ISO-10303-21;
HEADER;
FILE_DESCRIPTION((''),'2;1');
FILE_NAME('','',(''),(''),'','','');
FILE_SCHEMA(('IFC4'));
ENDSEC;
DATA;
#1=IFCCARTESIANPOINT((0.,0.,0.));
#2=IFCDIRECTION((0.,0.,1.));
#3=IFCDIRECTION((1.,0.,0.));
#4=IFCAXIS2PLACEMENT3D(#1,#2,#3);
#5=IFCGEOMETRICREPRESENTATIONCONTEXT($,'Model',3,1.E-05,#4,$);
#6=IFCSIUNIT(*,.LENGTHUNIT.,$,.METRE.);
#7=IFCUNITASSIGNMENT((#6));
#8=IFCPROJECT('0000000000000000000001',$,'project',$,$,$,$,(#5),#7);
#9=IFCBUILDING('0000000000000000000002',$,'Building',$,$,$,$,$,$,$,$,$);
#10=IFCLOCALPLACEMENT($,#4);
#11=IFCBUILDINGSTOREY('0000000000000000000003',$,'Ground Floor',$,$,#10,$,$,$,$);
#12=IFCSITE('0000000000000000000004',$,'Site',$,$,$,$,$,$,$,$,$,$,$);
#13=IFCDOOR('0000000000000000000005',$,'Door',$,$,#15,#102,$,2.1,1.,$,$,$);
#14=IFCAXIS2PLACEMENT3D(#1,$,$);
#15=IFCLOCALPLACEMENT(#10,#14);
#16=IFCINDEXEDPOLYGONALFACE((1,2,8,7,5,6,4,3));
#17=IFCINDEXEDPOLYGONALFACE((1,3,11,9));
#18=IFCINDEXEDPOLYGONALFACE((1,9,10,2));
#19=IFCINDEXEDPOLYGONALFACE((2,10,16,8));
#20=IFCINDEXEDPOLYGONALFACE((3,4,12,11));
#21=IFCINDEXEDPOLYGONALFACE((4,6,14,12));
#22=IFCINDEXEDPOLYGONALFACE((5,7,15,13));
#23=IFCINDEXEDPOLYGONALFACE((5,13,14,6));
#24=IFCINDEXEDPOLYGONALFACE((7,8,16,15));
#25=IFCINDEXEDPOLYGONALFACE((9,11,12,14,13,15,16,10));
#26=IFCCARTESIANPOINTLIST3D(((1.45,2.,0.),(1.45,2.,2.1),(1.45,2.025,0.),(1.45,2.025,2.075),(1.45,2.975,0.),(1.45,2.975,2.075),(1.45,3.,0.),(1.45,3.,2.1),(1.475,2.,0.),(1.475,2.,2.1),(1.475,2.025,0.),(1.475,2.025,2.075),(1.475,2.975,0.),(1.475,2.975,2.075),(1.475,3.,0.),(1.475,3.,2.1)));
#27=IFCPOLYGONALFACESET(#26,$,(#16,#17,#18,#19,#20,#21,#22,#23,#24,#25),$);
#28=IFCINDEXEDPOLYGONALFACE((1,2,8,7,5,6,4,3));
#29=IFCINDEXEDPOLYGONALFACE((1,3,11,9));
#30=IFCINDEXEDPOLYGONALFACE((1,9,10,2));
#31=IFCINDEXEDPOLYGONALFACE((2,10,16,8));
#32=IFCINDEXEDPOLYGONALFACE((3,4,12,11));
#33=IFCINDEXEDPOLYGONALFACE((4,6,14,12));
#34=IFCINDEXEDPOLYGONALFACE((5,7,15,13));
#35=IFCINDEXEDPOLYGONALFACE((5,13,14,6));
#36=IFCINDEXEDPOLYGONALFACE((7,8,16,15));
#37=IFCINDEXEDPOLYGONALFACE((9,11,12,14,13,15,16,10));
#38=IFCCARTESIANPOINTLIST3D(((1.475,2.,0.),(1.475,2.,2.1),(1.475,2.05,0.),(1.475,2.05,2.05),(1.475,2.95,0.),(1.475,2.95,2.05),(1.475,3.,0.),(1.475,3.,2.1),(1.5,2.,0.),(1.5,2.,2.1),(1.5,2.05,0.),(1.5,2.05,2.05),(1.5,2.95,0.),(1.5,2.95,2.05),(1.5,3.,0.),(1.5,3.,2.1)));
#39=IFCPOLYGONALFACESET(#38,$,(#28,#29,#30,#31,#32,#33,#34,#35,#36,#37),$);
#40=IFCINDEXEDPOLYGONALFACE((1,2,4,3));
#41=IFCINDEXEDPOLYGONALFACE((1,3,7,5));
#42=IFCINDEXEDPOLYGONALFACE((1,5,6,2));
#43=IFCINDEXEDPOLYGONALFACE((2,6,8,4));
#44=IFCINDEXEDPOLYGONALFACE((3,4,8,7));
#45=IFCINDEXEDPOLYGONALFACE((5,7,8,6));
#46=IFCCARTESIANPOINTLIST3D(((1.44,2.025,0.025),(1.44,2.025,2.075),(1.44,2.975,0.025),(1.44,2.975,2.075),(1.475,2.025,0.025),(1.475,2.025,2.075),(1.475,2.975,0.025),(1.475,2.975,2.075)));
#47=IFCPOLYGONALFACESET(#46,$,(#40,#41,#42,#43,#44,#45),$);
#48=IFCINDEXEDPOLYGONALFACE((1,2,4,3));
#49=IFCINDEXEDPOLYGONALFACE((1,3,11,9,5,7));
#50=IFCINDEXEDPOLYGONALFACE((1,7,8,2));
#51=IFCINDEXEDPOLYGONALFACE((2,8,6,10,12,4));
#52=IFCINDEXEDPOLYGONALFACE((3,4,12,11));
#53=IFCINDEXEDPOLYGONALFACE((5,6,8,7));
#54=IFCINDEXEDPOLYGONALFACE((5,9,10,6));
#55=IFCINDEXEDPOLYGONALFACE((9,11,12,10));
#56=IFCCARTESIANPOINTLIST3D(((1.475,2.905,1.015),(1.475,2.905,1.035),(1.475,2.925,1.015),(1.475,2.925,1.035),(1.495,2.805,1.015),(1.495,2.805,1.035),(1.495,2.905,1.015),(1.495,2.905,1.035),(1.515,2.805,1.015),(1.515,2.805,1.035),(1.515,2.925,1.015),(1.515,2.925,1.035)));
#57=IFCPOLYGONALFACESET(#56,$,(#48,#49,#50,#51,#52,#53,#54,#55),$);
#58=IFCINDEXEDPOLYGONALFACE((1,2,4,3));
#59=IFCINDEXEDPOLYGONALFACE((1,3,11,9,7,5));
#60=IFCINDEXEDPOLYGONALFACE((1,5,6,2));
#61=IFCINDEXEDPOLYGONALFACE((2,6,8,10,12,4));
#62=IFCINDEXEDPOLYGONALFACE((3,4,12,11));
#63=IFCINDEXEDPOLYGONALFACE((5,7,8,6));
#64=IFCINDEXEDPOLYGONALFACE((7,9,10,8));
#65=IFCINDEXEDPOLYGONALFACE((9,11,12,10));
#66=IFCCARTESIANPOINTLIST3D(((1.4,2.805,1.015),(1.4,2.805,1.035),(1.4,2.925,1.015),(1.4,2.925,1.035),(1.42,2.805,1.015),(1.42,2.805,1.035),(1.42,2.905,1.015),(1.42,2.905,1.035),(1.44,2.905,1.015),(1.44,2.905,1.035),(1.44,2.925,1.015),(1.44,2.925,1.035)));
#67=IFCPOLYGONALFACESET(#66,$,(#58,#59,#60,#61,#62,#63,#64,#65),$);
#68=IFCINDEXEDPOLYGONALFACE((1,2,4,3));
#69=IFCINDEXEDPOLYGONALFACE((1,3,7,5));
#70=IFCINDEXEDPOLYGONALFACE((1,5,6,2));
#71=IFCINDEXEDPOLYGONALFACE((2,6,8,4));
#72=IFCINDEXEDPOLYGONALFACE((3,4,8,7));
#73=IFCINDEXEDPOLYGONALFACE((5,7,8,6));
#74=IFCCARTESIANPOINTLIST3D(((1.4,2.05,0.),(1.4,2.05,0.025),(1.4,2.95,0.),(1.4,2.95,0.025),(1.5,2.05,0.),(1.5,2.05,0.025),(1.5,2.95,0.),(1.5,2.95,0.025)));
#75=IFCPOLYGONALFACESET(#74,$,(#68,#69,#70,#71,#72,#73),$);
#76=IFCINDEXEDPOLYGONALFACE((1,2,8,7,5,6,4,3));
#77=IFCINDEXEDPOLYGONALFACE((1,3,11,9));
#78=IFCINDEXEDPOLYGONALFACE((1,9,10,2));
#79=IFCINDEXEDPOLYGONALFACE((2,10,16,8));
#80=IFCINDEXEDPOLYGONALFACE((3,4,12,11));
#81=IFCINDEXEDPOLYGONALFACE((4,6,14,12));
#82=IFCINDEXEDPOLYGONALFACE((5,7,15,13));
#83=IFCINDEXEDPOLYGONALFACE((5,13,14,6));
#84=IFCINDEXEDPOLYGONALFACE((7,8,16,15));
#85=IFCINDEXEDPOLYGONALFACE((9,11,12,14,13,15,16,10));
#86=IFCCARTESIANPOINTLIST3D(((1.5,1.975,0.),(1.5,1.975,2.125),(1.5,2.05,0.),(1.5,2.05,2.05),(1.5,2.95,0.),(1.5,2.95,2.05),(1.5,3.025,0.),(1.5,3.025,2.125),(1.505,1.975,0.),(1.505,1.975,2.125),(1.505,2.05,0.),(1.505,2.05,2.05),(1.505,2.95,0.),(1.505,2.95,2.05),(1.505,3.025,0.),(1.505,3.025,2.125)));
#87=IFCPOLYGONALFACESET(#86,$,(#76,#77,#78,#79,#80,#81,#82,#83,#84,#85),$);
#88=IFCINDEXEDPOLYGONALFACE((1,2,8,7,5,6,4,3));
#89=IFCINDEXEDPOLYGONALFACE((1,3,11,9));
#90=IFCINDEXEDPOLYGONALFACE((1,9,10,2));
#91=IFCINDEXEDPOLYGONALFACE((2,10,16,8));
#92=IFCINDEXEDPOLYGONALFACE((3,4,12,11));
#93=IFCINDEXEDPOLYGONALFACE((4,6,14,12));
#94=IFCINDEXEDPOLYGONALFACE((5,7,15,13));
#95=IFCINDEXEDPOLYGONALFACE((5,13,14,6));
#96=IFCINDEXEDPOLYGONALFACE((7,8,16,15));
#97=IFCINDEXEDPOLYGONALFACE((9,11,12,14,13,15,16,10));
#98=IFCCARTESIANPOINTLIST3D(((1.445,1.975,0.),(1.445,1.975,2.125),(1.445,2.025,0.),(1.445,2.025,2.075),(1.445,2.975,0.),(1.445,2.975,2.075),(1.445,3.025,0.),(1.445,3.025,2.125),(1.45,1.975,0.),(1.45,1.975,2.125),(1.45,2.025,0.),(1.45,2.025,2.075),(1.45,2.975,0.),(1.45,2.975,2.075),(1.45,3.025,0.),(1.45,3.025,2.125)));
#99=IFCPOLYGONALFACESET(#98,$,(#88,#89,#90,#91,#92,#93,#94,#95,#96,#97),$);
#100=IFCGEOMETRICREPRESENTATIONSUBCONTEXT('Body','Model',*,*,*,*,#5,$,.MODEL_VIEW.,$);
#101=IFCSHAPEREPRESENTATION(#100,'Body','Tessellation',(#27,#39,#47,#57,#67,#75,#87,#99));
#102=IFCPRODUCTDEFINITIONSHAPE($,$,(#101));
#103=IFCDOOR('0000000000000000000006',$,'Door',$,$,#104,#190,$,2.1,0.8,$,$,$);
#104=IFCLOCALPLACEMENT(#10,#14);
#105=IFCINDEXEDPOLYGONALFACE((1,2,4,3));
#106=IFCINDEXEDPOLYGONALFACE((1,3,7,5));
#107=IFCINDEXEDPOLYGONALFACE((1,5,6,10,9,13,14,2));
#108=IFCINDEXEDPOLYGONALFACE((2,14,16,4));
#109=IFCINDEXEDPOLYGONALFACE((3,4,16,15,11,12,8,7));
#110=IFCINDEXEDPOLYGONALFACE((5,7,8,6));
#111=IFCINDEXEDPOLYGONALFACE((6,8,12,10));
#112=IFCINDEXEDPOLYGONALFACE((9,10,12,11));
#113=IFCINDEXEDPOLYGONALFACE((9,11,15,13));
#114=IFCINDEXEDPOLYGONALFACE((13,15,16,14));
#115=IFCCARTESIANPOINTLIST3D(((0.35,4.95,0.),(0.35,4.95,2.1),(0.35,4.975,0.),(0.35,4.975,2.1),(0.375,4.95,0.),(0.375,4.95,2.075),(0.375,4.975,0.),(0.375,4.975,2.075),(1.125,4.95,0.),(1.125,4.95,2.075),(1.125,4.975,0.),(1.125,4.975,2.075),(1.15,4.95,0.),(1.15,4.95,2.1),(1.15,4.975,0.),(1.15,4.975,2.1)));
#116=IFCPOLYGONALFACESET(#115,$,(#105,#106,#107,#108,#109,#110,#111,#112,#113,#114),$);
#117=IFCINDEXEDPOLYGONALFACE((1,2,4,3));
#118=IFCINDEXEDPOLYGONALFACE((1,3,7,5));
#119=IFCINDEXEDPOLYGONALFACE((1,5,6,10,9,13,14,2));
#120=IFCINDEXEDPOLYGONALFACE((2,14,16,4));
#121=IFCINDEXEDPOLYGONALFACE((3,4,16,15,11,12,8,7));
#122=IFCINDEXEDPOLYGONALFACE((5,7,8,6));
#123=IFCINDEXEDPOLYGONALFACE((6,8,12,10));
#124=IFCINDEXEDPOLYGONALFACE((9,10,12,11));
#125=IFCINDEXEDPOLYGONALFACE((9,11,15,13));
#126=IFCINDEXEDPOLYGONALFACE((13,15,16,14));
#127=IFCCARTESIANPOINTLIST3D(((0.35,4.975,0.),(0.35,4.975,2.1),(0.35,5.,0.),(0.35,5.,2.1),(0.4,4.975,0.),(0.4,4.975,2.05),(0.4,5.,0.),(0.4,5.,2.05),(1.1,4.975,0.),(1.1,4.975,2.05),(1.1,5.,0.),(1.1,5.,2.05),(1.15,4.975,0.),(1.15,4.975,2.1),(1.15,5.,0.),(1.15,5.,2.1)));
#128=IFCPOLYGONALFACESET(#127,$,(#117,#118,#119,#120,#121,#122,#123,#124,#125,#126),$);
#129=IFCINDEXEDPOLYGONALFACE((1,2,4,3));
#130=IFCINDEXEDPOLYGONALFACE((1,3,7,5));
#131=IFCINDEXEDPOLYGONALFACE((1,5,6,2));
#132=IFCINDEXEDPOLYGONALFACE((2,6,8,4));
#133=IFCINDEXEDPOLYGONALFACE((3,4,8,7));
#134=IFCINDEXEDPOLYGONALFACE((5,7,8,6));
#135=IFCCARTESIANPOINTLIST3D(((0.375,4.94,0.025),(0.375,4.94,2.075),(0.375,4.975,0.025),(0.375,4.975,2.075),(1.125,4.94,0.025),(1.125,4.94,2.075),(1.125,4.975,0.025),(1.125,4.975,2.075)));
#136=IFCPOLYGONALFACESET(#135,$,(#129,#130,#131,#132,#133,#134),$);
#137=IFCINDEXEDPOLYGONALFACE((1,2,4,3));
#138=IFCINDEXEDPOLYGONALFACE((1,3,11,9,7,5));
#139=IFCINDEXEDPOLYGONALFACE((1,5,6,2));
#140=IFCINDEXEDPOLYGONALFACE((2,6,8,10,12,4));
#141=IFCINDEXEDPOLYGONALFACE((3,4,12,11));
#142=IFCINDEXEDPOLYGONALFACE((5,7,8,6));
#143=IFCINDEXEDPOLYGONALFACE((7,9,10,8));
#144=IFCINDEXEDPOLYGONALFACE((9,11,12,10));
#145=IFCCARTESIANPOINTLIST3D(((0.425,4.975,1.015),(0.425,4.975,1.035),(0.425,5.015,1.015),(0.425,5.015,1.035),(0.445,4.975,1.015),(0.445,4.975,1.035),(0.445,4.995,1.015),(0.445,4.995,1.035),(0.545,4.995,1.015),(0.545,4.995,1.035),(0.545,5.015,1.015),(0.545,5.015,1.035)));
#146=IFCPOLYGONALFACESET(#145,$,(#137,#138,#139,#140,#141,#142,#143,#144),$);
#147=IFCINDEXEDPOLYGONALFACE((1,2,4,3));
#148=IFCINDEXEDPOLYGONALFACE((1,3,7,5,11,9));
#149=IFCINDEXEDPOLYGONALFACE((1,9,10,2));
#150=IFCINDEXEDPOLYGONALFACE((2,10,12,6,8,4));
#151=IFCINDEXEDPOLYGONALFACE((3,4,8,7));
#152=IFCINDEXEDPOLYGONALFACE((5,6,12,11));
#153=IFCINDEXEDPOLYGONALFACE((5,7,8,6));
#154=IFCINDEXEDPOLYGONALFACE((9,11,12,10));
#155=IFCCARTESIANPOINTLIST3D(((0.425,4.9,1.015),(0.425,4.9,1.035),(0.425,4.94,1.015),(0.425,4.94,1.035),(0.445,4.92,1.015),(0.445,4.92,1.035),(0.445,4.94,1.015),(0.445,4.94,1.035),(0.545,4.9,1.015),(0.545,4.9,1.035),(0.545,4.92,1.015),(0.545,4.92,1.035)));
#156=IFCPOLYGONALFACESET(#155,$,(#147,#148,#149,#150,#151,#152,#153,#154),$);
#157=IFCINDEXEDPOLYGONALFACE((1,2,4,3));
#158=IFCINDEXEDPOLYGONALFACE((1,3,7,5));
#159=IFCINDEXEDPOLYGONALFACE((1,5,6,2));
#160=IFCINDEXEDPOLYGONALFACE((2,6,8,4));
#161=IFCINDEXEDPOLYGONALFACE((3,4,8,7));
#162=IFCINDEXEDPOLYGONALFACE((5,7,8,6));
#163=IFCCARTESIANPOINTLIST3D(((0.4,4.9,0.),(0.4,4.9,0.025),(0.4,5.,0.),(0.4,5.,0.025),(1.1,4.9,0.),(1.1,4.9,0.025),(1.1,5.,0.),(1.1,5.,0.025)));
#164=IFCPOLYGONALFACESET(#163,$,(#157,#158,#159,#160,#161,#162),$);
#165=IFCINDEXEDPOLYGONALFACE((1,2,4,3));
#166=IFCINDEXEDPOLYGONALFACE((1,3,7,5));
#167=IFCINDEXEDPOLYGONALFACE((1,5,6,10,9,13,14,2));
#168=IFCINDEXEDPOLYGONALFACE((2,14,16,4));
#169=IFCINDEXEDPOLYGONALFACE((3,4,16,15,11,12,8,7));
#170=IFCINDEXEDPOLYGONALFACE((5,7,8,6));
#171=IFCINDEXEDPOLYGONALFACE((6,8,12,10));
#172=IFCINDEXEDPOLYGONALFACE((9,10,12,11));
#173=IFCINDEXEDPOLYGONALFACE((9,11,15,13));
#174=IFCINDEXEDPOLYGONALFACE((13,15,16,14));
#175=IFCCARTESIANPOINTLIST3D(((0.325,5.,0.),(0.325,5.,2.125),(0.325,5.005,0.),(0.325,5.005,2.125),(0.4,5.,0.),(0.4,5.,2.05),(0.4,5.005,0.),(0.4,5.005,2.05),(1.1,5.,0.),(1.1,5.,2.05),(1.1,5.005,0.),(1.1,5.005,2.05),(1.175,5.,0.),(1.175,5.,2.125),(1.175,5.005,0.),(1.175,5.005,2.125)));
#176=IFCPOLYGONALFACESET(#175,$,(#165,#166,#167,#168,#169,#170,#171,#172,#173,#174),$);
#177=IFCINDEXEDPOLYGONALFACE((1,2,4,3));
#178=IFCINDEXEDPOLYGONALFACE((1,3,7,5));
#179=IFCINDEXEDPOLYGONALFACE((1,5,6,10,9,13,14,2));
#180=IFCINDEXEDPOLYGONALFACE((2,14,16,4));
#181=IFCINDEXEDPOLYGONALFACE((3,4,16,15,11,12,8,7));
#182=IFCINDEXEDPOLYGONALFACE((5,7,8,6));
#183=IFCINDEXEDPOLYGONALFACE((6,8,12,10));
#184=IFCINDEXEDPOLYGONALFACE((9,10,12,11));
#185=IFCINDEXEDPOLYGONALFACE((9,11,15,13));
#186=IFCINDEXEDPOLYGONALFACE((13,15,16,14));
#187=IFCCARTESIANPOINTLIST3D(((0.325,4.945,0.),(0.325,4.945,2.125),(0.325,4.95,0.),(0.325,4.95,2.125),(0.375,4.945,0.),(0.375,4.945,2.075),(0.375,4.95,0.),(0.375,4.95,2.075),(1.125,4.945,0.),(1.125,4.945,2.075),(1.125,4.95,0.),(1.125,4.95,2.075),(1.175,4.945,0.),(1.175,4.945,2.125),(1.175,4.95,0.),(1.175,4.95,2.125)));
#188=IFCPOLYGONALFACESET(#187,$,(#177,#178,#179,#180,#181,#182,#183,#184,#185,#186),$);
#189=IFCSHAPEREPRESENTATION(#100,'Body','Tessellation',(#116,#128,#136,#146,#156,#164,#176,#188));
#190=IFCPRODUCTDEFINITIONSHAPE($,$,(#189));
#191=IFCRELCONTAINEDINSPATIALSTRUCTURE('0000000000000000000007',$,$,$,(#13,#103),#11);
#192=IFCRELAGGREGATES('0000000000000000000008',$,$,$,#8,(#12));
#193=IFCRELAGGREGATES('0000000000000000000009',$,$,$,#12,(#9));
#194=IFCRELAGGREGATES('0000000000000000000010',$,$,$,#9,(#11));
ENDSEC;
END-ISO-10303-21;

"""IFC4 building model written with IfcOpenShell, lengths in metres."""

from ifc_helpers import new_model, si_unit, frame, origin_with_axes, place, context, subcontext, project, spatial, line, indexed_curve, outline, extrude, element, save


model = new_model("IFC4")

# Units and contexts
model_context = context("Model", 3, precision=1e-05, world=origin_with_axes())
body_context = subcontext(model_context, "Body", "Model", "MODEL_VIEW")
ifc_project = project(units=[si_unit("LENGTHUNIT", "METRE")], contexts=[model_context])

# Site, building, storey
site = spatial("IfcSite", under=ifc_project, Name="Site")
building = spatial("IfcBuilding", under=site, Name="Building")
storey_placement = place(None, origin_with_axes())
storey = spatial("IfcBuildingStorey", under=building, at=storey_placement, Name="Ground Floor")

# Doors
door_1_placement = place(storey_placement, frame((1.5, 2.0, 0.0), z_axis=(0.0, 0.0, 1.0), x_axis=(0.0, 1.0, 0.0)))
element("IfcDoor", 1, at=door_1_placement, inside=storey, Name="Door", OverallHeight=2.1, OverallWidth=1.0, context=body_context, shape_type="SweptSolid", body=[
    extrude(outline(indexed_curve([(0.0, 0.0), (0.0, 2.1), (1.0, 2.1), (1.0, 0.0), (0.975, 0.0), (0.975, 2.075), (0.025, 2.075), (0.025, 0.0)], segments=[line(1, 2, 3, 4, 5, 6, 7, 8, 1)])), frame((0.0, 0.025, 0.0), z_axis=(0.0, -1.0, 0.0), x_axis=(1.0, 0.0, 0.0)), (0.0, 0.0, -1.0), 0.025),
    extrude(outline(indexed_curve([(0.0, 0.0), (0.0, 2.1), (1.0, 2.1), (1.0, 0.0), (0.95, 0.0), (0.95, 2.05), (0.05, 2.05), (0.05, 0.0)], segments=[line(1, 2, 3, 4, 5, 6, 7, 8, 1)])), frame((0.0, 0.0, 0.0), z_axis=(0.0, -1.0, 0.0), x_axis=(1.0, 0.0, 0.0)), (0.0, 0.0, -1.0), 0.025),
    extrude(outline(indexed_curve([(0.0, 0.0), (0.95, 0.0), (0.95, 0.035), (0.0, 0.035)], segments=[line(1, 2, 3, 4, 1)])), frame((0.025, 0.025, 0.025), z_axis=(0.0, 0.0, 1.0), x_axis=(1.0, 0.0, 0.0)), (0.0, 0.0, 1.0), 2.05),
    extrude(outline(indexed_curve([(0.0, 0.0), (0.0, -0.04), (-0.12, -0.04), (-0.12, -0.02), (-0.02, -0.02), (-0.02, 0.0)], segments=[line(1, 2, 3, 4, 5, 6, 1)])), frame((0.925, 0.025, 1.015), z_axis=(0.0, 0.0, 1.0), x_axis=(1.0, 0.0, 0.0)), (0.0, 0.0, 1.0), 0.02),
    extrude(outline(indexed_curve([(0.0, 0.0), (0.0, 0.04), (-0.12, 0.04), (-0.12, 0.02), (-0.02, 0.02), (-0.02, 0.0)], segments=[line(1, 2, 3, 4, 5, 6, 1)])), frame((0.925, 0.06, 1.015), z_axis=(0.0, 0.0, 1.0), x_axis=(1.0, 0.0, 0.0)), (0.0, 0.0, 1.0), 0.02),
    extrude(outline(indexed_curve([(0.0, 0.0), (0.9, 0.0), (0.9, 0.1), (0.0, 0.1)], segments=[line(1, 2, 3, 4, 1)])), frame((0.05, 0.0, 0.0), z_axis=(0.0, 0.0, 1.0), x_axis=(1.0, 0.0, 0.0)), (0.0, 0.0, 1.0), 0.025),
    extrude(outline(indexed_curve([(0.0, 0.0), (0.0, 2.125), (1.05, 2.125), (1.05, 0.0), (0.975, 0.0), (0.975, 2.05), (0.075, 2.05), (0.075, 0.0)], segments=[line(1, 2, 3, 4, 5, 6, 7, 8, 1)])), frame((-0.025, -0.005, 0.0), z_axis=(0.0, -1.0, 0.0), x_axis=(1.0, 0.0, 0.0)), (0.0, 0.0, -1.0), 0.005),
    extrude(outline(indexed_curve([(0.0, 0.0), (0.0, 2.125), (1.05, 2.125), (1.05, 0.0), (1.0, 0.0), (1.0, 2.075), (0.05, 2.075), (0.05, 0.0)], segments=[line(1, 2, 3, 4, 5, 6, 7, 8, 1)])), frame((-0.025, 0.05, 0.0), z_axis=(0.0, -1.0, 0.0), x_axis=(1.0, 0.0, 0.0)), (0.0, 0.0, -1.0), 0.005),
])
door_2_placement = place(storey_placement, frame((1.15, 5.0, 0.0), z_axis=(0.0, 0.0, 1.0), x_axis=(-1.0, 0.0, 0.0)))
element("IfcDoor", 2, at=door_2_placement, inside=storey, Name="Door", OverallHeight=2.1, OverallWidth=0.8, context=body_context, shape_type="SweptSolid", body=[
    extrude(outline(indexed_curve([(0.0, 0.0), (0.0, 2.1), (0.8, 2.1), (0.8, 0.0), (0.775, 0.0), (0.775, 2.075), (0.025, 2.075), (0.025, 0.0)], segments=[line(1, 2, 3, 4, 5, 6, 7, 8, 1)])), frame((0.0, 0.025, 0.0), z_axis=(0.0, -1.0, 0.0), x_axis=(1.0, 0.0, 0.0)), (0.0, 0.0, -1.0), 0.025),
    extrude(outline(indexed_curve([(0.0, 0.0), (0.0, 2.1), (0.8, 2.1), (0.8, 0.0), (0.75, 0.0), (0.75, 2.05), (0.05, 2.05), (0.05, 0.0)], segments=[line(1, 2, 3, 4, 5, 6, 7, 8, 1)])), frame((0.0, 0.0, 0.0), z_axis=(0.0, -1.0, 0.0), x_axis=(1.0, 0.0, 0.0)), (0.0, 0.0, -1.0), 0.025),
    extrude(outline(indexed_curve([(0.0, 0.0), (0.75, 0.0), (0.75, 0.035), (0.0, 0.035)], segments=[line(1, 2, 3, 4, 1)])), frame((0.025, 0.025, 0.025), z_axis=(0.0, 0.0, 1.0), x_axis=(1.0, 0.0, 0.0)), (0.0, 0.0, 1.0), 2.05),
    extrude(outline(indexed_curve([(0.0, 0.0), (0.0, -0.04), (-0.12, -0.04), (-0.12, -0.02), (-0.02, -0.02), (-0.02, 0.0)], segments=[line(1, 2, 3, 4, 5, 6, 1)])), frame((0.725, 0.025, 1.015), z_axis=(0.0, 0.0, 1.0), x_axis=(1.0, 0.0, 0.0)), (0.0, 0.0, 1.0), 0.02),
    extrude(outline(indexed_curve([(0.0, 0.0), (0.0, 0.04), (-0.12, 0.04), (-0.12, 0.02), (-0.02, 0.02), (-0.02, 0.0)], segments=[line(1, 2, 3, 4, 5, 6, 1)])), frame((0.725, 0.06, 1.015), z_axis=(0.0, 0.0, 1.0), x_axis=(1.0, 0.0, 0.0)), (0.0, 0.0, 1.0), 0.02),
    extrude(outline(indexed_curve([(0.0, 0.0), (0.7, 0.0), (0.7, 0.1), (0.0, 0.1)], segments=[line(1, 2, 3, 4, 1)])), frame((0.05, 0.0, 0.0), z_axis=(0.0, 0.0, 1.0), x_axis=(1.0, 0.0, 0.0)), (0.0, 0.0, 1.0), 0.025),
    extrude(outline(indexed_curve([(0.0, 0.0), (0.0, 2.125), (0.85, 2.125), (0.85, 0.0), (0.775, 0.0), (0.775, 2.05), (0.075, 2.05), (0.075, 0.0)], segments=[line(1, 2, 3, 4, 5, 6, 7, 8, 1)])), frame((-0.025, -0.005, 0.0), z_axis=(0.0, -1.0, 0.0), x_axis=(1.0, 0.0, 0.0)), (0.0, 0.0, -1.0), 0.005),
    extrude(outline(indexed_curve([(0.0, 0.0), (0.0, 2.125), (0.85, 2.125), (0.85, 0.0), (0.8, 0.0), (0.8, 2.075), (0.05, 2.075), (0.05, 0.0)], segments=[line(1, 2, 3, 4, 5, 6, 7, 8, 1)])), frame((-0.025, 0.05, 0.0), z_axis=(0.0, -1.0, 0.0), x_axis=(1.0, 0.0, 0.0)), (0.0, 0.0, -1.0), 0.005),
])

save(model, "model.ifc")
